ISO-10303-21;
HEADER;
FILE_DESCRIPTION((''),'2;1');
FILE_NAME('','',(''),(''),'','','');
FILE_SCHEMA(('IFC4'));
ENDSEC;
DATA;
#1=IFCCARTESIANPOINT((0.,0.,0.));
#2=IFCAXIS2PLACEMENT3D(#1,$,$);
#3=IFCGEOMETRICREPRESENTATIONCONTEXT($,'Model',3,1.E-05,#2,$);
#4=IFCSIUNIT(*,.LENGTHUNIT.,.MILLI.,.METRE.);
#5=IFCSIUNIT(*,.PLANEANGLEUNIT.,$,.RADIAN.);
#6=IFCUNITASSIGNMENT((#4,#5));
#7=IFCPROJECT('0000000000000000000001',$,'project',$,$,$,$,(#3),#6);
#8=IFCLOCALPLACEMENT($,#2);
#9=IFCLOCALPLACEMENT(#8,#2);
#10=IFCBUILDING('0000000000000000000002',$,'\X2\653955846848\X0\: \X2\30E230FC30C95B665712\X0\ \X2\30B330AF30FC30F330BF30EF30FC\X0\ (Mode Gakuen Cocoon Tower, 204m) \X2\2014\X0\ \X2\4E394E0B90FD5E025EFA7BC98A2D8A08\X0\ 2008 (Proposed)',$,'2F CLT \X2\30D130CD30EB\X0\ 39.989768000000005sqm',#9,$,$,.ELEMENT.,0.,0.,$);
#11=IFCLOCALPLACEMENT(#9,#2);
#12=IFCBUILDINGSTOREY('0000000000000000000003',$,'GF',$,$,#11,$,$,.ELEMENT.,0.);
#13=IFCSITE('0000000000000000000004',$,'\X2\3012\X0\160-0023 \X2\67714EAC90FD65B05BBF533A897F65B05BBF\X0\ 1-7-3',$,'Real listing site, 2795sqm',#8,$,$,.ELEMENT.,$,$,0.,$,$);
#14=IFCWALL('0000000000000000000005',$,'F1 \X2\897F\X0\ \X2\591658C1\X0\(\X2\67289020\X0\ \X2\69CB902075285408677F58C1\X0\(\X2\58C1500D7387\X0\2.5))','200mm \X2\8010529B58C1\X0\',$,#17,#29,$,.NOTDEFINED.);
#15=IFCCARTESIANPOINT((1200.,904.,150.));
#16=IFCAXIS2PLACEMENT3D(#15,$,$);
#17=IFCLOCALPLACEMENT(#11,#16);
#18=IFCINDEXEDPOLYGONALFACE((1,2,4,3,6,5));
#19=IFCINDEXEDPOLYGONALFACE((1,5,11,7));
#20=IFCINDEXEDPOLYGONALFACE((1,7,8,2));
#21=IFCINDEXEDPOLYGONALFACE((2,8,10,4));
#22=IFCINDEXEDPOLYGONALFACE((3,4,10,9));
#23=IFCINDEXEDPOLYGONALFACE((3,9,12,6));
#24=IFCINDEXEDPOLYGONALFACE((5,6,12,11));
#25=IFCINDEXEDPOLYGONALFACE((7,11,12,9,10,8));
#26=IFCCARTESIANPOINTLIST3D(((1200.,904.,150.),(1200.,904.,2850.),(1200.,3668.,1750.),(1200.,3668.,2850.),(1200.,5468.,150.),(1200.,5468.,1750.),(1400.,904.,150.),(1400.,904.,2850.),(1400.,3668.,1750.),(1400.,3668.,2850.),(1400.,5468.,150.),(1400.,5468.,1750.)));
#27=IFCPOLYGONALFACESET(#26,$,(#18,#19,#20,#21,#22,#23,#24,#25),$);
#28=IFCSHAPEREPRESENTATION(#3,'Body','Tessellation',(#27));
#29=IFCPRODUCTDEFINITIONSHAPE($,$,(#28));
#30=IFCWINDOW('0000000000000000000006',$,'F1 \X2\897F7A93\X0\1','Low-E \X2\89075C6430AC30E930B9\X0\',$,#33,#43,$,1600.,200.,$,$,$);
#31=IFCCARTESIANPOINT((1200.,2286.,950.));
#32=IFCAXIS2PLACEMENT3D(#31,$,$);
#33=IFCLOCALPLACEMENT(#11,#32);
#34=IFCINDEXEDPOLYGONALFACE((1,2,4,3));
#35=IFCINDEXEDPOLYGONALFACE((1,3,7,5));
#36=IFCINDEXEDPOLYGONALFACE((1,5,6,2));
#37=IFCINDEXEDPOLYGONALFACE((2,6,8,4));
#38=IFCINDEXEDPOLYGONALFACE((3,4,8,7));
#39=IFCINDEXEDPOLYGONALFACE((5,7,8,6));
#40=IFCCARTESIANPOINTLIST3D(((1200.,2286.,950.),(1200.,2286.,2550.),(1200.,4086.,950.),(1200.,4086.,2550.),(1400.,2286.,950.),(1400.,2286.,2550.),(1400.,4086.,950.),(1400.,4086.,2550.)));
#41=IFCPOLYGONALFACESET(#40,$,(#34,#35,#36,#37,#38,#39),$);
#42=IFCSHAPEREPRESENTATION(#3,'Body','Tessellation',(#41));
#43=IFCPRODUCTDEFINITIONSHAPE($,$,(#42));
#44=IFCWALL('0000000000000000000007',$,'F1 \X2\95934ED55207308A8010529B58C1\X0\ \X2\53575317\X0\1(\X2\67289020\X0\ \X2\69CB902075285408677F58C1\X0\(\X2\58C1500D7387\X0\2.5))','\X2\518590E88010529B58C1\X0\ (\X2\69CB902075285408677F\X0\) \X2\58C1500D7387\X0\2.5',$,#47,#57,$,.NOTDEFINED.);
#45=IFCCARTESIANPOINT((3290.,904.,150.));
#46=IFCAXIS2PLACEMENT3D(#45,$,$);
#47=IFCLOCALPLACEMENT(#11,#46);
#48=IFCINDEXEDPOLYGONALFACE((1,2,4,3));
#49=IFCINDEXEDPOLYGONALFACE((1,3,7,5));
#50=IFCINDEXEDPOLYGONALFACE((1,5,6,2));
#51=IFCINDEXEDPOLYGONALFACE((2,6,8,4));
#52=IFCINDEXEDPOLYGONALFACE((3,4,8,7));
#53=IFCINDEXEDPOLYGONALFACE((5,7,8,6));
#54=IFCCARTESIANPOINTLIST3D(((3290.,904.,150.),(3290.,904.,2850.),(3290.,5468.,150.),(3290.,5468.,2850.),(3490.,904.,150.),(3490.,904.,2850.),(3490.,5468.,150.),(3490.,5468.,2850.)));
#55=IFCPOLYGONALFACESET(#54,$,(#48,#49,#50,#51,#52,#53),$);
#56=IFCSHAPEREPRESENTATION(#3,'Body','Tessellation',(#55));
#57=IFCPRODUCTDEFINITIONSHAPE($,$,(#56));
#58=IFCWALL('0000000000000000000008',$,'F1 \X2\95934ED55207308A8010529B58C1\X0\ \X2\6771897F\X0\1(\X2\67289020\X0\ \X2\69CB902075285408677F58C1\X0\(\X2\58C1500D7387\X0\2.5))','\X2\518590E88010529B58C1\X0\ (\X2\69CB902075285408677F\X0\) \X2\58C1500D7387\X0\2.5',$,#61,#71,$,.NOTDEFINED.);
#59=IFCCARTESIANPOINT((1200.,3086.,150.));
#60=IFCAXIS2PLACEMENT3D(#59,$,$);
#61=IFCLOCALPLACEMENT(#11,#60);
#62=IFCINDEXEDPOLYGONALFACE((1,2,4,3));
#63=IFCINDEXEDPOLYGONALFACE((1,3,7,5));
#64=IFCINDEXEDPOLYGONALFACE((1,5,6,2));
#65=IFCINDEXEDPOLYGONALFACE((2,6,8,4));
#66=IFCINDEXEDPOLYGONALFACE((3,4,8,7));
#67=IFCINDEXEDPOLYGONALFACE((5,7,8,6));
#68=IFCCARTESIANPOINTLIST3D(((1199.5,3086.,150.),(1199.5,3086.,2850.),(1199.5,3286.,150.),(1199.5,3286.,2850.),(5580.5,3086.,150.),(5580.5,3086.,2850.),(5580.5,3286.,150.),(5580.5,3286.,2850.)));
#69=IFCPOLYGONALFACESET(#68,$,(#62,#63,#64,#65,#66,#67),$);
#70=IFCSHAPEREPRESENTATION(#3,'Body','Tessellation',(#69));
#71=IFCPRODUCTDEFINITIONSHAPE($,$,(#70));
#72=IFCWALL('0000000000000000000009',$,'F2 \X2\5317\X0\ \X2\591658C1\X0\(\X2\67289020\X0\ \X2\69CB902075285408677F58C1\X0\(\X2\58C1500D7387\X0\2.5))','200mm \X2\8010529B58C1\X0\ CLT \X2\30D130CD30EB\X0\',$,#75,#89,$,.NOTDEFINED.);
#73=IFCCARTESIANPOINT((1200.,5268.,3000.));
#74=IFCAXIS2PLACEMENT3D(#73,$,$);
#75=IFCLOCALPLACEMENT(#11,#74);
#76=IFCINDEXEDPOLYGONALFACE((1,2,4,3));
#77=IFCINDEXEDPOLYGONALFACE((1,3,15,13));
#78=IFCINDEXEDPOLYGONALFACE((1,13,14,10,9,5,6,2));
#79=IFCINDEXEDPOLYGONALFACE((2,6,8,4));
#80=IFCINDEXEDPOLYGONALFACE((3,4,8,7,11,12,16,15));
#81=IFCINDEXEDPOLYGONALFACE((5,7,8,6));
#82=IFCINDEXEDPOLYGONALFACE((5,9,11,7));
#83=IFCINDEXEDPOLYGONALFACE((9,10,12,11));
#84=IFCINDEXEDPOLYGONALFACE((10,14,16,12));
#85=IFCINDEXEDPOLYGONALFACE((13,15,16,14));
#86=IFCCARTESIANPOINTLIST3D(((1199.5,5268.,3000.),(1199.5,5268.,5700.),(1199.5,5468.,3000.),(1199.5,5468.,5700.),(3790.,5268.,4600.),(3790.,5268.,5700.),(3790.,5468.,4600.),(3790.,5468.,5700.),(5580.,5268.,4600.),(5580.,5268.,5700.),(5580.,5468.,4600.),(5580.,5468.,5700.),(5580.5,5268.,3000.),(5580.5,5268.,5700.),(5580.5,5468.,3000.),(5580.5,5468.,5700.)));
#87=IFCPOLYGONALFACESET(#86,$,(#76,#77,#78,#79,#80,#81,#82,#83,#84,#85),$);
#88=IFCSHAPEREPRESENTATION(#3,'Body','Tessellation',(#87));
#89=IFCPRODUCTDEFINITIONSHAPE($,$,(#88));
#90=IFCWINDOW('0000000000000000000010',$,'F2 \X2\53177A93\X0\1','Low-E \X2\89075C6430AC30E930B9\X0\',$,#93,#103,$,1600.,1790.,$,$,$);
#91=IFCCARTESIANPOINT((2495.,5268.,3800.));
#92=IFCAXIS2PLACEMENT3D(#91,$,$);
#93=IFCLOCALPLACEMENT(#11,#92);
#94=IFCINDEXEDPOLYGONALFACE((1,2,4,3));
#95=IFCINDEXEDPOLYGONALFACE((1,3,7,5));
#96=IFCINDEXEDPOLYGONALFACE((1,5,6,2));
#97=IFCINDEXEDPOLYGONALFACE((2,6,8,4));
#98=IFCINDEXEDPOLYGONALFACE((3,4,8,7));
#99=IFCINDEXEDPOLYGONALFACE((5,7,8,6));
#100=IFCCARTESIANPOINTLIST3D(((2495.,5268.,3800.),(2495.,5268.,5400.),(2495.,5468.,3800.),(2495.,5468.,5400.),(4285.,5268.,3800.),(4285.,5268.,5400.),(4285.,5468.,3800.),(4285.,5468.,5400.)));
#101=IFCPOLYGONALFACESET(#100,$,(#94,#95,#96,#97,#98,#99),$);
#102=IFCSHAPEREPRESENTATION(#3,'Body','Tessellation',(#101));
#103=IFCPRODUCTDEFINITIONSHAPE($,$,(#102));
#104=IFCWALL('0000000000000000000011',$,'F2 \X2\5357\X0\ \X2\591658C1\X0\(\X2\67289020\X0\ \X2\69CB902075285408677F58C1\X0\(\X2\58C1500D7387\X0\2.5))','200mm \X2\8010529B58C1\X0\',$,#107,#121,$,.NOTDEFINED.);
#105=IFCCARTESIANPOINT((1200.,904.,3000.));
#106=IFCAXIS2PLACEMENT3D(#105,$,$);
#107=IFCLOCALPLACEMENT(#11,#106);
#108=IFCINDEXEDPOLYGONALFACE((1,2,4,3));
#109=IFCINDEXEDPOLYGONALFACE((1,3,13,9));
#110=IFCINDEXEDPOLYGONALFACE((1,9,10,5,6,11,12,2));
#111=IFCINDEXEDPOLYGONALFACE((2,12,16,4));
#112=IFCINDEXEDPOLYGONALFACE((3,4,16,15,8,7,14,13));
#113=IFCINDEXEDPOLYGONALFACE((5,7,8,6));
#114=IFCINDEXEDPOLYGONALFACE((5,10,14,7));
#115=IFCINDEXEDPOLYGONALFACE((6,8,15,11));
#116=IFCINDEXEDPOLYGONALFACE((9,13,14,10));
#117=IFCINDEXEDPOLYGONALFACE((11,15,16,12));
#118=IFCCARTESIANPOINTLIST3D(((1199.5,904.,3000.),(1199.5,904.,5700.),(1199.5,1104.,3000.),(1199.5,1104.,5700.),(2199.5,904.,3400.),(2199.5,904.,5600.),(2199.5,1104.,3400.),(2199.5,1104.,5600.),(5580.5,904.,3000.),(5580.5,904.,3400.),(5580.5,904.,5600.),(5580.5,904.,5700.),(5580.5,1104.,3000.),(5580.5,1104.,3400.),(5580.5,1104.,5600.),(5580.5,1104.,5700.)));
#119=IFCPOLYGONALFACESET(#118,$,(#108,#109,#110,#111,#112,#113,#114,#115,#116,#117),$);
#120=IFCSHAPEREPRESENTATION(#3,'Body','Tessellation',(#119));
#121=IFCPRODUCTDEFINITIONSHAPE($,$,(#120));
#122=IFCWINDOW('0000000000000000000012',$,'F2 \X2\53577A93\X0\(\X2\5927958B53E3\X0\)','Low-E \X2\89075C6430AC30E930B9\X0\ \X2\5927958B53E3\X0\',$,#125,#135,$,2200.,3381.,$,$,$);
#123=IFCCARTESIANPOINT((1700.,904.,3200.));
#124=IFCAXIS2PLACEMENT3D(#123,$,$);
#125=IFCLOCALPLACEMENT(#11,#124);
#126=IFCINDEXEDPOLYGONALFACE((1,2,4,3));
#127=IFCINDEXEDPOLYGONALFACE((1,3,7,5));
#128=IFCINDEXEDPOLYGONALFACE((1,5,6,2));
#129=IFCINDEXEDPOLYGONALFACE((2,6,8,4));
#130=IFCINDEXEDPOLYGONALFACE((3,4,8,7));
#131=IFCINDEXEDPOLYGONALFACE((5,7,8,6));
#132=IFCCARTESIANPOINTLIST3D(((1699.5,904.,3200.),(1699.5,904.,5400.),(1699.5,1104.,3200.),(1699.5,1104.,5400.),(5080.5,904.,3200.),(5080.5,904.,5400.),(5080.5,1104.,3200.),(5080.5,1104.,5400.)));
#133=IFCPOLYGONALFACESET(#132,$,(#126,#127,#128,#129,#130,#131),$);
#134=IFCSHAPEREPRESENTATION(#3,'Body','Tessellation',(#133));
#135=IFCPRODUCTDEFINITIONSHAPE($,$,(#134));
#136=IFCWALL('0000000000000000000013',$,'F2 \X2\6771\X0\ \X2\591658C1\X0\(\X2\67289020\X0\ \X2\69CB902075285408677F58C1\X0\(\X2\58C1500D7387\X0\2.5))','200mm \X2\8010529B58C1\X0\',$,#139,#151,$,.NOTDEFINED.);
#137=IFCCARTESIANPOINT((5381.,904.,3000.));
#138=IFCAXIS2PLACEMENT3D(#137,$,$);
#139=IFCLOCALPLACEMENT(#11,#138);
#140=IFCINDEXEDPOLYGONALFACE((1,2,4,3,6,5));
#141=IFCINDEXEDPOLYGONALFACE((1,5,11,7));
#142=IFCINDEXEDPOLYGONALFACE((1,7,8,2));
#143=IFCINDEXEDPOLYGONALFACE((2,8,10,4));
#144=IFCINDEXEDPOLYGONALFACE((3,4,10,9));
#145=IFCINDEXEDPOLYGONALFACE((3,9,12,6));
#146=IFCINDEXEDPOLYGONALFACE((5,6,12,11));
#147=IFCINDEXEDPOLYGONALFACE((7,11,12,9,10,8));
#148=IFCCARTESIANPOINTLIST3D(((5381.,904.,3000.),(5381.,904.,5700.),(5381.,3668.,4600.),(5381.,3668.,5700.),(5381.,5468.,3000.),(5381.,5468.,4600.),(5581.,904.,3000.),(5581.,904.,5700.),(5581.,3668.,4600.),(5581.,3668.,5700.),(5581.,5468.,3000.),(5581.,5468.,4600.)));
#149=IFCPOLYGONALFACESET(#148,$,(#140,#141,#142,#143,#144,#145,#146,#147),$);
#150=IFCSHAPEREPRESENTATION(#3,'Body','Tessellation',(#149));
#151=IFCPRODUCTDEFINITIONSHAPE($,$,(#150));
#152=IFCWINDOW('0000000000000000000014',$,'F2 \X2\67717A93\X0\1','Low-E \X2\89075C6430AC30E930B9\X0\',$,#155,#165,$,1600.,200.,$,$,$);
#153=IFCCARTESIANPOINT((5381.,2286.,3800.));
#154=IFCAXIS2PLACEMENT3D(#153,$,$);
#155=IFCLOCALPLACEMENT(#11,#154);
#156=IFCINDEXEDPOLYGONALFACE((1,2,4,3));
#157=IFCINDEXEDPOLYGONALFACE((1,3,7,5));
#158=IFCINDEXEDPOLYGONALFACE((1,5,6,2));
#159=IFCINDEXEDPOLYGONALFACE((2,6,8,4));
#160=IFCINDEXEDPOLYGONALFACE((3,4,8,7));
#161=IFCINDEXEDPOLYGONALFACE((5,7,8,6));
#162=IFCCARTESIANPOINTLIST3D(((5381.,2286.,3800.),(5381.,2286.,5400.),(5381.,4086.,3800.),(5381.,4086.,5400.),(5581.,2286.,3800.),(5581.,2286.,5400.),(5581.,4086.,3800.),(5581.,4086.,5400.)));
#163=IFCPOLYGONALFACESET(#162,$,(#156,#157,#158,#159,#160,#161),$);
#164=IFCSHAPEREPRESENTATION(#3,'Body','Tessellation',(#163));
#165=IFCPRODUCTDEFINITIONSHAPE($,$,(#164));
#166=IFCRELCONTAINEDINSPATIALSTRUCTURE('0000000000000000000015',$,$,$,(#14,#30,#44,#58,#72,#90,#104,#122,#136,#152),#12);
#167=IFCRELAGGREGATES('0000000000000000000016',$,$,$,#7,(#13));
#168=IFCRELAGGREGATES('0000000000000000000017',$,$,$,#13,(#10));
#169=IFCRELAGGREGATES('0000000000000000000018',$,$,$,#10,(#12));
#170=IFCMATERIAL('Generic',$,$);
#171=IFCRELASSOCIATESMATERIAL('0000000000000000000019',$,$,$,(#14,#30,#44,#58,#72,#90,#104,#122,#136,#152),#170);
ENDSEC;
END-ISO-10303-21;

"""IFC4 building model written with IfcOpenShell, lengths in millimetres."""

from ifc_helpers import new_model, si_unit, frame, frame_2d, origin, place, context, project, spatial, rectangle, extrude, material, element, fill, save


model = new_model("IFC4")

# Units and contexts
model_context = context("Model", 3, precision=1e-05, world=origin())
ifc_project = project(units=[si_unit("LENGTHUNIT", "METRE", prefix="MILLI"), si_unit("PLANEANGLEUNIT", "RADIAN")], contexts=[model_context])

# Site, building, storey
site_placement = place(None, origin())
site = spatial("IfcSite", under=ifc_project, at=site_placement, Name="〒160-0023 東京都新宿区西新宿 1-7-3", ObjectType="Real listing site, 2795sqm", CompositionType="ELEMENT", RefElevation=0.0)
building_placement = place(site_placement, origin())
building = spatial("IfcBuilding", under=site, at=building_placement, Name="改善案: モード学園 コクーンタワー (Mode Gakuen Cocoon Tower, 204m) — 丹下都市建築設計 2008 (Proposed)", ObjectType="2F CLT パネル 39.989768000000005sqm", CompositionType="ELEMENT", ElevationOfRefHeight=0.0, ElevationOfTerrain=0.0)
storey_placement = place(building_placement, origin())
storey = spatial("IfcBuildingStorey", under=building, at=storey_placement, Name="GF", CompositionType="ELEMENT", Elevation=0.0)

# Shared definitions
ifc_material_1 = material(Name="Generic")

# Wall, opening, window
wall_1_placement = place(storey_placement, frame((1200.0, 904.0, 150.0)))
wall_1 = element("IfcWall", 1, at=wall_1_placement, inside=storey, material=ifc_material_1, Name="F1 西 外壁(木造 構造用合板壁(壁倍率2.5))", Description="200mm 耐力壁", PredefinedType="NOTDEFINED", context=model_context, shape_type="SweptSolid", body=[
    extrude(rectangle(XDim=200.0, YDim=4564.0, at=frame_2d((100.0, 2282.0))), frame((1200.0, 904.0, 150.0)), (0.0, 0.0, 1.0), 2700.0),
])
opening_1_placement = place(storey_placement, frame((1200.0, 2286.0, 950.0)))
opening_1 = element("IfcOpeningElement", 2, at=opening_1_placement, cuts=wall_1, PredefinedType="NOTDEFINED", context=model_context, shape_type="SweptSolid", body=[
    extrude(rectangle(XDim=200.0, YDim=1800.0, at=frame_2d((100.0, 900.0))), frame((1200.0, 2286.0, 950.0)), (0.0, 0.0, 1.0), 1600.0),
])
window_1_placement = place(storey_placement, frame((1200.0, 2286.0, 950.0)))
window_1 = element("IfcWindow", 3, at=window_1_placement, inside=storey, material=ifc_material_1, Name="F1 西窓1", Description="Low-E 複層ガラス", OverallHeight=1600.0, OverallWidth=200.0, context=model_context, shape_type="SweptSolid", body=[
    extrude(rectangle(XDim=200.0, YDim=1800.0, at=frame_2d((100.0, 900.0))), frame((1200.0, 2286.0, 950.0)), (0.0, 0.0, 1.0), 1600.0),
])
fill(opening_1, window_1)

# Walls
wall_2_placement = place(storey_placement, frame((3290.0, 904.0, 150.0)))
element("IfcWall", 4, at=wall_2_placement, inside=storey, material=ifc_material_1, Name="F1 間仕切り耐力壁 南北1(木造 構造用合板壁(壁倍率2.5))", Description="内部耐力壁 (構造用合板) 壁倍率2.5", PredefinedType="NOTDEFINED", context=model_context, shape_type="SweptSolid", body=[
    extrude(rectangle(XDim=200.0, YDim=4564.0, at=frame_2d((100.0, 2282.0))), frame((3290.0, 904.0, 150.0)), (0.0, 0.0, 1.0), 2700.0),
])
wall_3_placement = place(storey_placement, frame((1200.0, 3086.0, 150.0)))
element("IfcWall", 5, at=wall_3_placement, inside=storey, material=ifc_material_1, Name="F1 間仕切り耐力壁 東西1(木造 構造用合板壁(壁倍率2.5))", Description="内部耐力壁 (構造用合板) 壁倍率2.5", PredefinedType="NOTDEFINED", context=model_context, shape_type="SweptSolid", body=[
    extrude(rectangle(XDim=4381.0, YDim=200.0, at=frame_2d((2190.0, 100.0))), frame((1200.0, 3086.0, 150.0)), (0.0, 0.0, 1.0), 2700.0),
])

# Walls, openings, windows
wall_4_placement = place(storey_placement, frame((1200.0, 5268.0, 3000.0)))
wall_4 = element("IfcWall", 6, at=wall_4_placement, inside=storey, material=ifc_material_1, Name="F2 北 外壁(木造 構造用合板壁(壁倍率2.5))", Description="200mm 耐力壁 CLT パネル", PredefinedType="NOTDEFINED", context=model_context, shape_type="SweptSolid", body=[
    extrude(rectangle(XDim=4381.0, YDim=200.0, at=frame_2d((2190.0, 100.0))), frame((1200.0, 5268.0, 3000.0)), (0.0, 0.0, 1.0), 2700.0),
])
opening_2_placement = place(storey_placement, frame((2495.0, 5268.0, 3800.0)))
opening_2 = element("IfcOpeningElement", 7, at=opening_2_placement, cuts=wall_4, PredefinedType="NOTDEFINED", context=model_context, shape_type="SweptSolid", body=[
    extrude(rectangle(XDim=1790.0, YDim=200.0, at=frame_2d((895.0, 100.0))), frame((2495.0, 5268.0, 3800.0)), (0.0, 0.0, 1.0), 1600.0),
])
window_2_placement = place(storey_placement, frame((2495.0, 5268.0, 3800.0)))
window_2 = element("IfcWindow", 8, at=window_2_placement, inside=storey, material=ifc_material_1, Name="F2 北窓1", Description="Low-E 複層ガラス", OverallHeight=1600.0, OverallWidth=1790.0, context=model_context, shape_type="SweptSolid", body=[
    extrude(rectangle(XDim=1790.0, YDim=200.0, at=frame_2d((895.0, 100.0))), frame((2495.0, 5268.0, 3800.0)), (0.0, 0.0, 1.0), 1600.0),
])
fill(opening_2, window_2)
wall_5_placement = place(storey_placement, frame((1200.0, 904.0, 3000.0)))
wall_5 = element("IfcWall", 9, at=wall_5_placement, inside=storey, material=ifc_material_1, Name="F2 南 外壁(木造 構造用合板壁(壁倍率2.5))", Description="200mm 耐力壁", PredefinedType="NOTDEFINED", context=model_context, shape_type="SweptSolid", body=[
    extrude(rectangle(XDim=4381.0, YDim=200.0, at=frame_2d((2190.0, 100.0))), frame((1200.0, 904.0, 3000.0)), (0.0, 0.0, 1.0), 2700.0),
])
opening_3_placement = place(storey_placement, frame((1700.0, 904.0, 3200.0)))
opening_3 = element("IfcOpeningElement", 10, at=opening_3_placement, cuts=wall_5, PredefinedType="NOTDEFINED", context=model_context, shape_type="SweptSolid", body=[
    extrude(rectangle(XDim=3381.0, YDim=200.0, at=frame_2d((1690.0, 100.0))), frame((1700.0, 904.0, 3200.0)), (0.0, 0.0, 1.0), 2200.0),
])
window_3_placement = place(storey_placement, frame((1700.0, 904.0, 3200.0)))
window_3 = element("IfcWindow", 11, at=window_3_placement, inside=storey, material=ifc_material_1, Name="F2 南窓(大開口)", Description="Low-E 複層ガラス 大開口", OverallHeight=2200.0, OverallWidth=3381.0, context=model_context, shape_type="SweptSolid", body=[
    extrude(rectangle(XDim=3381.0, YDim=200.0, at=frame_2d((1690.0, 100.0))), frame((1700.0, 904.0, 3200.0)), (0.0, 0.0, 1.0), 2200.0),
])
fill(opening_3, window_3)
wall_6_placement = place(storey_placement, frame((5381.0, 904.0, 3000.0)))
wall_6 = element("IfcWall", 12, at=wall_6_placement, inside=storey, material=ifc_material_1, Name="F2 東 外壁(木造 構造用合板壁(壁倍率2.5))", Description="200mm 耐力壁", PredefinedType="NOTDEFINED", context=model_context, shape_type="SweptSolid", body=[
    extrude(rectangle(XDim=200.0, YDim=4564.0, at=frame_2d((100.0, 2282.0))), frame((5381.0, 904.0, 3000.0)), (0.0, 0.0, 1.0), 2700.0),
])
opening_4_placement = place(storey_placement, frame((5381.0, 2286.0, 3800.0)))
opening_4 = element("IfcOpeningElement", 13, at=opening_4_placement, cuts=wall_6, PredefinedType="NOTDEFINED", context=model_context, shape_type="SweptSolid", body=[
    extrude(rectangle(XDim=200.0, YDim=1800.0, at=frame_2d((100.0, 900.0))), frame((5381.0, 2286.0, 3800.0)), (0.0, 0.0, 1.0), 1600.0),
])
window_4_placement = place(storey_placement, frame((5381.0, 2286.0, 3800.0)))
window_4 = element("IfcWindow", 14, at=window_4_placement, inside=storey, material=ifc_material_1, Name="F2 東窓1", Description="Low-E 複層ガラス", OverallHeight=1600.0, OverallWidth=200.0, context=model_context, shape_type="SweptSolid", body=[
    extrude(rectangle(XDim=200.0, YDim=1800.0, at=frame_2d((100.0, 900.0))), frame((5381.0, 2286.0, 3800.0)), (0.0, 0.0, 1.0), 1600.0),
])
fill(opening_4, window_4)

save(model, "model.ifc")
